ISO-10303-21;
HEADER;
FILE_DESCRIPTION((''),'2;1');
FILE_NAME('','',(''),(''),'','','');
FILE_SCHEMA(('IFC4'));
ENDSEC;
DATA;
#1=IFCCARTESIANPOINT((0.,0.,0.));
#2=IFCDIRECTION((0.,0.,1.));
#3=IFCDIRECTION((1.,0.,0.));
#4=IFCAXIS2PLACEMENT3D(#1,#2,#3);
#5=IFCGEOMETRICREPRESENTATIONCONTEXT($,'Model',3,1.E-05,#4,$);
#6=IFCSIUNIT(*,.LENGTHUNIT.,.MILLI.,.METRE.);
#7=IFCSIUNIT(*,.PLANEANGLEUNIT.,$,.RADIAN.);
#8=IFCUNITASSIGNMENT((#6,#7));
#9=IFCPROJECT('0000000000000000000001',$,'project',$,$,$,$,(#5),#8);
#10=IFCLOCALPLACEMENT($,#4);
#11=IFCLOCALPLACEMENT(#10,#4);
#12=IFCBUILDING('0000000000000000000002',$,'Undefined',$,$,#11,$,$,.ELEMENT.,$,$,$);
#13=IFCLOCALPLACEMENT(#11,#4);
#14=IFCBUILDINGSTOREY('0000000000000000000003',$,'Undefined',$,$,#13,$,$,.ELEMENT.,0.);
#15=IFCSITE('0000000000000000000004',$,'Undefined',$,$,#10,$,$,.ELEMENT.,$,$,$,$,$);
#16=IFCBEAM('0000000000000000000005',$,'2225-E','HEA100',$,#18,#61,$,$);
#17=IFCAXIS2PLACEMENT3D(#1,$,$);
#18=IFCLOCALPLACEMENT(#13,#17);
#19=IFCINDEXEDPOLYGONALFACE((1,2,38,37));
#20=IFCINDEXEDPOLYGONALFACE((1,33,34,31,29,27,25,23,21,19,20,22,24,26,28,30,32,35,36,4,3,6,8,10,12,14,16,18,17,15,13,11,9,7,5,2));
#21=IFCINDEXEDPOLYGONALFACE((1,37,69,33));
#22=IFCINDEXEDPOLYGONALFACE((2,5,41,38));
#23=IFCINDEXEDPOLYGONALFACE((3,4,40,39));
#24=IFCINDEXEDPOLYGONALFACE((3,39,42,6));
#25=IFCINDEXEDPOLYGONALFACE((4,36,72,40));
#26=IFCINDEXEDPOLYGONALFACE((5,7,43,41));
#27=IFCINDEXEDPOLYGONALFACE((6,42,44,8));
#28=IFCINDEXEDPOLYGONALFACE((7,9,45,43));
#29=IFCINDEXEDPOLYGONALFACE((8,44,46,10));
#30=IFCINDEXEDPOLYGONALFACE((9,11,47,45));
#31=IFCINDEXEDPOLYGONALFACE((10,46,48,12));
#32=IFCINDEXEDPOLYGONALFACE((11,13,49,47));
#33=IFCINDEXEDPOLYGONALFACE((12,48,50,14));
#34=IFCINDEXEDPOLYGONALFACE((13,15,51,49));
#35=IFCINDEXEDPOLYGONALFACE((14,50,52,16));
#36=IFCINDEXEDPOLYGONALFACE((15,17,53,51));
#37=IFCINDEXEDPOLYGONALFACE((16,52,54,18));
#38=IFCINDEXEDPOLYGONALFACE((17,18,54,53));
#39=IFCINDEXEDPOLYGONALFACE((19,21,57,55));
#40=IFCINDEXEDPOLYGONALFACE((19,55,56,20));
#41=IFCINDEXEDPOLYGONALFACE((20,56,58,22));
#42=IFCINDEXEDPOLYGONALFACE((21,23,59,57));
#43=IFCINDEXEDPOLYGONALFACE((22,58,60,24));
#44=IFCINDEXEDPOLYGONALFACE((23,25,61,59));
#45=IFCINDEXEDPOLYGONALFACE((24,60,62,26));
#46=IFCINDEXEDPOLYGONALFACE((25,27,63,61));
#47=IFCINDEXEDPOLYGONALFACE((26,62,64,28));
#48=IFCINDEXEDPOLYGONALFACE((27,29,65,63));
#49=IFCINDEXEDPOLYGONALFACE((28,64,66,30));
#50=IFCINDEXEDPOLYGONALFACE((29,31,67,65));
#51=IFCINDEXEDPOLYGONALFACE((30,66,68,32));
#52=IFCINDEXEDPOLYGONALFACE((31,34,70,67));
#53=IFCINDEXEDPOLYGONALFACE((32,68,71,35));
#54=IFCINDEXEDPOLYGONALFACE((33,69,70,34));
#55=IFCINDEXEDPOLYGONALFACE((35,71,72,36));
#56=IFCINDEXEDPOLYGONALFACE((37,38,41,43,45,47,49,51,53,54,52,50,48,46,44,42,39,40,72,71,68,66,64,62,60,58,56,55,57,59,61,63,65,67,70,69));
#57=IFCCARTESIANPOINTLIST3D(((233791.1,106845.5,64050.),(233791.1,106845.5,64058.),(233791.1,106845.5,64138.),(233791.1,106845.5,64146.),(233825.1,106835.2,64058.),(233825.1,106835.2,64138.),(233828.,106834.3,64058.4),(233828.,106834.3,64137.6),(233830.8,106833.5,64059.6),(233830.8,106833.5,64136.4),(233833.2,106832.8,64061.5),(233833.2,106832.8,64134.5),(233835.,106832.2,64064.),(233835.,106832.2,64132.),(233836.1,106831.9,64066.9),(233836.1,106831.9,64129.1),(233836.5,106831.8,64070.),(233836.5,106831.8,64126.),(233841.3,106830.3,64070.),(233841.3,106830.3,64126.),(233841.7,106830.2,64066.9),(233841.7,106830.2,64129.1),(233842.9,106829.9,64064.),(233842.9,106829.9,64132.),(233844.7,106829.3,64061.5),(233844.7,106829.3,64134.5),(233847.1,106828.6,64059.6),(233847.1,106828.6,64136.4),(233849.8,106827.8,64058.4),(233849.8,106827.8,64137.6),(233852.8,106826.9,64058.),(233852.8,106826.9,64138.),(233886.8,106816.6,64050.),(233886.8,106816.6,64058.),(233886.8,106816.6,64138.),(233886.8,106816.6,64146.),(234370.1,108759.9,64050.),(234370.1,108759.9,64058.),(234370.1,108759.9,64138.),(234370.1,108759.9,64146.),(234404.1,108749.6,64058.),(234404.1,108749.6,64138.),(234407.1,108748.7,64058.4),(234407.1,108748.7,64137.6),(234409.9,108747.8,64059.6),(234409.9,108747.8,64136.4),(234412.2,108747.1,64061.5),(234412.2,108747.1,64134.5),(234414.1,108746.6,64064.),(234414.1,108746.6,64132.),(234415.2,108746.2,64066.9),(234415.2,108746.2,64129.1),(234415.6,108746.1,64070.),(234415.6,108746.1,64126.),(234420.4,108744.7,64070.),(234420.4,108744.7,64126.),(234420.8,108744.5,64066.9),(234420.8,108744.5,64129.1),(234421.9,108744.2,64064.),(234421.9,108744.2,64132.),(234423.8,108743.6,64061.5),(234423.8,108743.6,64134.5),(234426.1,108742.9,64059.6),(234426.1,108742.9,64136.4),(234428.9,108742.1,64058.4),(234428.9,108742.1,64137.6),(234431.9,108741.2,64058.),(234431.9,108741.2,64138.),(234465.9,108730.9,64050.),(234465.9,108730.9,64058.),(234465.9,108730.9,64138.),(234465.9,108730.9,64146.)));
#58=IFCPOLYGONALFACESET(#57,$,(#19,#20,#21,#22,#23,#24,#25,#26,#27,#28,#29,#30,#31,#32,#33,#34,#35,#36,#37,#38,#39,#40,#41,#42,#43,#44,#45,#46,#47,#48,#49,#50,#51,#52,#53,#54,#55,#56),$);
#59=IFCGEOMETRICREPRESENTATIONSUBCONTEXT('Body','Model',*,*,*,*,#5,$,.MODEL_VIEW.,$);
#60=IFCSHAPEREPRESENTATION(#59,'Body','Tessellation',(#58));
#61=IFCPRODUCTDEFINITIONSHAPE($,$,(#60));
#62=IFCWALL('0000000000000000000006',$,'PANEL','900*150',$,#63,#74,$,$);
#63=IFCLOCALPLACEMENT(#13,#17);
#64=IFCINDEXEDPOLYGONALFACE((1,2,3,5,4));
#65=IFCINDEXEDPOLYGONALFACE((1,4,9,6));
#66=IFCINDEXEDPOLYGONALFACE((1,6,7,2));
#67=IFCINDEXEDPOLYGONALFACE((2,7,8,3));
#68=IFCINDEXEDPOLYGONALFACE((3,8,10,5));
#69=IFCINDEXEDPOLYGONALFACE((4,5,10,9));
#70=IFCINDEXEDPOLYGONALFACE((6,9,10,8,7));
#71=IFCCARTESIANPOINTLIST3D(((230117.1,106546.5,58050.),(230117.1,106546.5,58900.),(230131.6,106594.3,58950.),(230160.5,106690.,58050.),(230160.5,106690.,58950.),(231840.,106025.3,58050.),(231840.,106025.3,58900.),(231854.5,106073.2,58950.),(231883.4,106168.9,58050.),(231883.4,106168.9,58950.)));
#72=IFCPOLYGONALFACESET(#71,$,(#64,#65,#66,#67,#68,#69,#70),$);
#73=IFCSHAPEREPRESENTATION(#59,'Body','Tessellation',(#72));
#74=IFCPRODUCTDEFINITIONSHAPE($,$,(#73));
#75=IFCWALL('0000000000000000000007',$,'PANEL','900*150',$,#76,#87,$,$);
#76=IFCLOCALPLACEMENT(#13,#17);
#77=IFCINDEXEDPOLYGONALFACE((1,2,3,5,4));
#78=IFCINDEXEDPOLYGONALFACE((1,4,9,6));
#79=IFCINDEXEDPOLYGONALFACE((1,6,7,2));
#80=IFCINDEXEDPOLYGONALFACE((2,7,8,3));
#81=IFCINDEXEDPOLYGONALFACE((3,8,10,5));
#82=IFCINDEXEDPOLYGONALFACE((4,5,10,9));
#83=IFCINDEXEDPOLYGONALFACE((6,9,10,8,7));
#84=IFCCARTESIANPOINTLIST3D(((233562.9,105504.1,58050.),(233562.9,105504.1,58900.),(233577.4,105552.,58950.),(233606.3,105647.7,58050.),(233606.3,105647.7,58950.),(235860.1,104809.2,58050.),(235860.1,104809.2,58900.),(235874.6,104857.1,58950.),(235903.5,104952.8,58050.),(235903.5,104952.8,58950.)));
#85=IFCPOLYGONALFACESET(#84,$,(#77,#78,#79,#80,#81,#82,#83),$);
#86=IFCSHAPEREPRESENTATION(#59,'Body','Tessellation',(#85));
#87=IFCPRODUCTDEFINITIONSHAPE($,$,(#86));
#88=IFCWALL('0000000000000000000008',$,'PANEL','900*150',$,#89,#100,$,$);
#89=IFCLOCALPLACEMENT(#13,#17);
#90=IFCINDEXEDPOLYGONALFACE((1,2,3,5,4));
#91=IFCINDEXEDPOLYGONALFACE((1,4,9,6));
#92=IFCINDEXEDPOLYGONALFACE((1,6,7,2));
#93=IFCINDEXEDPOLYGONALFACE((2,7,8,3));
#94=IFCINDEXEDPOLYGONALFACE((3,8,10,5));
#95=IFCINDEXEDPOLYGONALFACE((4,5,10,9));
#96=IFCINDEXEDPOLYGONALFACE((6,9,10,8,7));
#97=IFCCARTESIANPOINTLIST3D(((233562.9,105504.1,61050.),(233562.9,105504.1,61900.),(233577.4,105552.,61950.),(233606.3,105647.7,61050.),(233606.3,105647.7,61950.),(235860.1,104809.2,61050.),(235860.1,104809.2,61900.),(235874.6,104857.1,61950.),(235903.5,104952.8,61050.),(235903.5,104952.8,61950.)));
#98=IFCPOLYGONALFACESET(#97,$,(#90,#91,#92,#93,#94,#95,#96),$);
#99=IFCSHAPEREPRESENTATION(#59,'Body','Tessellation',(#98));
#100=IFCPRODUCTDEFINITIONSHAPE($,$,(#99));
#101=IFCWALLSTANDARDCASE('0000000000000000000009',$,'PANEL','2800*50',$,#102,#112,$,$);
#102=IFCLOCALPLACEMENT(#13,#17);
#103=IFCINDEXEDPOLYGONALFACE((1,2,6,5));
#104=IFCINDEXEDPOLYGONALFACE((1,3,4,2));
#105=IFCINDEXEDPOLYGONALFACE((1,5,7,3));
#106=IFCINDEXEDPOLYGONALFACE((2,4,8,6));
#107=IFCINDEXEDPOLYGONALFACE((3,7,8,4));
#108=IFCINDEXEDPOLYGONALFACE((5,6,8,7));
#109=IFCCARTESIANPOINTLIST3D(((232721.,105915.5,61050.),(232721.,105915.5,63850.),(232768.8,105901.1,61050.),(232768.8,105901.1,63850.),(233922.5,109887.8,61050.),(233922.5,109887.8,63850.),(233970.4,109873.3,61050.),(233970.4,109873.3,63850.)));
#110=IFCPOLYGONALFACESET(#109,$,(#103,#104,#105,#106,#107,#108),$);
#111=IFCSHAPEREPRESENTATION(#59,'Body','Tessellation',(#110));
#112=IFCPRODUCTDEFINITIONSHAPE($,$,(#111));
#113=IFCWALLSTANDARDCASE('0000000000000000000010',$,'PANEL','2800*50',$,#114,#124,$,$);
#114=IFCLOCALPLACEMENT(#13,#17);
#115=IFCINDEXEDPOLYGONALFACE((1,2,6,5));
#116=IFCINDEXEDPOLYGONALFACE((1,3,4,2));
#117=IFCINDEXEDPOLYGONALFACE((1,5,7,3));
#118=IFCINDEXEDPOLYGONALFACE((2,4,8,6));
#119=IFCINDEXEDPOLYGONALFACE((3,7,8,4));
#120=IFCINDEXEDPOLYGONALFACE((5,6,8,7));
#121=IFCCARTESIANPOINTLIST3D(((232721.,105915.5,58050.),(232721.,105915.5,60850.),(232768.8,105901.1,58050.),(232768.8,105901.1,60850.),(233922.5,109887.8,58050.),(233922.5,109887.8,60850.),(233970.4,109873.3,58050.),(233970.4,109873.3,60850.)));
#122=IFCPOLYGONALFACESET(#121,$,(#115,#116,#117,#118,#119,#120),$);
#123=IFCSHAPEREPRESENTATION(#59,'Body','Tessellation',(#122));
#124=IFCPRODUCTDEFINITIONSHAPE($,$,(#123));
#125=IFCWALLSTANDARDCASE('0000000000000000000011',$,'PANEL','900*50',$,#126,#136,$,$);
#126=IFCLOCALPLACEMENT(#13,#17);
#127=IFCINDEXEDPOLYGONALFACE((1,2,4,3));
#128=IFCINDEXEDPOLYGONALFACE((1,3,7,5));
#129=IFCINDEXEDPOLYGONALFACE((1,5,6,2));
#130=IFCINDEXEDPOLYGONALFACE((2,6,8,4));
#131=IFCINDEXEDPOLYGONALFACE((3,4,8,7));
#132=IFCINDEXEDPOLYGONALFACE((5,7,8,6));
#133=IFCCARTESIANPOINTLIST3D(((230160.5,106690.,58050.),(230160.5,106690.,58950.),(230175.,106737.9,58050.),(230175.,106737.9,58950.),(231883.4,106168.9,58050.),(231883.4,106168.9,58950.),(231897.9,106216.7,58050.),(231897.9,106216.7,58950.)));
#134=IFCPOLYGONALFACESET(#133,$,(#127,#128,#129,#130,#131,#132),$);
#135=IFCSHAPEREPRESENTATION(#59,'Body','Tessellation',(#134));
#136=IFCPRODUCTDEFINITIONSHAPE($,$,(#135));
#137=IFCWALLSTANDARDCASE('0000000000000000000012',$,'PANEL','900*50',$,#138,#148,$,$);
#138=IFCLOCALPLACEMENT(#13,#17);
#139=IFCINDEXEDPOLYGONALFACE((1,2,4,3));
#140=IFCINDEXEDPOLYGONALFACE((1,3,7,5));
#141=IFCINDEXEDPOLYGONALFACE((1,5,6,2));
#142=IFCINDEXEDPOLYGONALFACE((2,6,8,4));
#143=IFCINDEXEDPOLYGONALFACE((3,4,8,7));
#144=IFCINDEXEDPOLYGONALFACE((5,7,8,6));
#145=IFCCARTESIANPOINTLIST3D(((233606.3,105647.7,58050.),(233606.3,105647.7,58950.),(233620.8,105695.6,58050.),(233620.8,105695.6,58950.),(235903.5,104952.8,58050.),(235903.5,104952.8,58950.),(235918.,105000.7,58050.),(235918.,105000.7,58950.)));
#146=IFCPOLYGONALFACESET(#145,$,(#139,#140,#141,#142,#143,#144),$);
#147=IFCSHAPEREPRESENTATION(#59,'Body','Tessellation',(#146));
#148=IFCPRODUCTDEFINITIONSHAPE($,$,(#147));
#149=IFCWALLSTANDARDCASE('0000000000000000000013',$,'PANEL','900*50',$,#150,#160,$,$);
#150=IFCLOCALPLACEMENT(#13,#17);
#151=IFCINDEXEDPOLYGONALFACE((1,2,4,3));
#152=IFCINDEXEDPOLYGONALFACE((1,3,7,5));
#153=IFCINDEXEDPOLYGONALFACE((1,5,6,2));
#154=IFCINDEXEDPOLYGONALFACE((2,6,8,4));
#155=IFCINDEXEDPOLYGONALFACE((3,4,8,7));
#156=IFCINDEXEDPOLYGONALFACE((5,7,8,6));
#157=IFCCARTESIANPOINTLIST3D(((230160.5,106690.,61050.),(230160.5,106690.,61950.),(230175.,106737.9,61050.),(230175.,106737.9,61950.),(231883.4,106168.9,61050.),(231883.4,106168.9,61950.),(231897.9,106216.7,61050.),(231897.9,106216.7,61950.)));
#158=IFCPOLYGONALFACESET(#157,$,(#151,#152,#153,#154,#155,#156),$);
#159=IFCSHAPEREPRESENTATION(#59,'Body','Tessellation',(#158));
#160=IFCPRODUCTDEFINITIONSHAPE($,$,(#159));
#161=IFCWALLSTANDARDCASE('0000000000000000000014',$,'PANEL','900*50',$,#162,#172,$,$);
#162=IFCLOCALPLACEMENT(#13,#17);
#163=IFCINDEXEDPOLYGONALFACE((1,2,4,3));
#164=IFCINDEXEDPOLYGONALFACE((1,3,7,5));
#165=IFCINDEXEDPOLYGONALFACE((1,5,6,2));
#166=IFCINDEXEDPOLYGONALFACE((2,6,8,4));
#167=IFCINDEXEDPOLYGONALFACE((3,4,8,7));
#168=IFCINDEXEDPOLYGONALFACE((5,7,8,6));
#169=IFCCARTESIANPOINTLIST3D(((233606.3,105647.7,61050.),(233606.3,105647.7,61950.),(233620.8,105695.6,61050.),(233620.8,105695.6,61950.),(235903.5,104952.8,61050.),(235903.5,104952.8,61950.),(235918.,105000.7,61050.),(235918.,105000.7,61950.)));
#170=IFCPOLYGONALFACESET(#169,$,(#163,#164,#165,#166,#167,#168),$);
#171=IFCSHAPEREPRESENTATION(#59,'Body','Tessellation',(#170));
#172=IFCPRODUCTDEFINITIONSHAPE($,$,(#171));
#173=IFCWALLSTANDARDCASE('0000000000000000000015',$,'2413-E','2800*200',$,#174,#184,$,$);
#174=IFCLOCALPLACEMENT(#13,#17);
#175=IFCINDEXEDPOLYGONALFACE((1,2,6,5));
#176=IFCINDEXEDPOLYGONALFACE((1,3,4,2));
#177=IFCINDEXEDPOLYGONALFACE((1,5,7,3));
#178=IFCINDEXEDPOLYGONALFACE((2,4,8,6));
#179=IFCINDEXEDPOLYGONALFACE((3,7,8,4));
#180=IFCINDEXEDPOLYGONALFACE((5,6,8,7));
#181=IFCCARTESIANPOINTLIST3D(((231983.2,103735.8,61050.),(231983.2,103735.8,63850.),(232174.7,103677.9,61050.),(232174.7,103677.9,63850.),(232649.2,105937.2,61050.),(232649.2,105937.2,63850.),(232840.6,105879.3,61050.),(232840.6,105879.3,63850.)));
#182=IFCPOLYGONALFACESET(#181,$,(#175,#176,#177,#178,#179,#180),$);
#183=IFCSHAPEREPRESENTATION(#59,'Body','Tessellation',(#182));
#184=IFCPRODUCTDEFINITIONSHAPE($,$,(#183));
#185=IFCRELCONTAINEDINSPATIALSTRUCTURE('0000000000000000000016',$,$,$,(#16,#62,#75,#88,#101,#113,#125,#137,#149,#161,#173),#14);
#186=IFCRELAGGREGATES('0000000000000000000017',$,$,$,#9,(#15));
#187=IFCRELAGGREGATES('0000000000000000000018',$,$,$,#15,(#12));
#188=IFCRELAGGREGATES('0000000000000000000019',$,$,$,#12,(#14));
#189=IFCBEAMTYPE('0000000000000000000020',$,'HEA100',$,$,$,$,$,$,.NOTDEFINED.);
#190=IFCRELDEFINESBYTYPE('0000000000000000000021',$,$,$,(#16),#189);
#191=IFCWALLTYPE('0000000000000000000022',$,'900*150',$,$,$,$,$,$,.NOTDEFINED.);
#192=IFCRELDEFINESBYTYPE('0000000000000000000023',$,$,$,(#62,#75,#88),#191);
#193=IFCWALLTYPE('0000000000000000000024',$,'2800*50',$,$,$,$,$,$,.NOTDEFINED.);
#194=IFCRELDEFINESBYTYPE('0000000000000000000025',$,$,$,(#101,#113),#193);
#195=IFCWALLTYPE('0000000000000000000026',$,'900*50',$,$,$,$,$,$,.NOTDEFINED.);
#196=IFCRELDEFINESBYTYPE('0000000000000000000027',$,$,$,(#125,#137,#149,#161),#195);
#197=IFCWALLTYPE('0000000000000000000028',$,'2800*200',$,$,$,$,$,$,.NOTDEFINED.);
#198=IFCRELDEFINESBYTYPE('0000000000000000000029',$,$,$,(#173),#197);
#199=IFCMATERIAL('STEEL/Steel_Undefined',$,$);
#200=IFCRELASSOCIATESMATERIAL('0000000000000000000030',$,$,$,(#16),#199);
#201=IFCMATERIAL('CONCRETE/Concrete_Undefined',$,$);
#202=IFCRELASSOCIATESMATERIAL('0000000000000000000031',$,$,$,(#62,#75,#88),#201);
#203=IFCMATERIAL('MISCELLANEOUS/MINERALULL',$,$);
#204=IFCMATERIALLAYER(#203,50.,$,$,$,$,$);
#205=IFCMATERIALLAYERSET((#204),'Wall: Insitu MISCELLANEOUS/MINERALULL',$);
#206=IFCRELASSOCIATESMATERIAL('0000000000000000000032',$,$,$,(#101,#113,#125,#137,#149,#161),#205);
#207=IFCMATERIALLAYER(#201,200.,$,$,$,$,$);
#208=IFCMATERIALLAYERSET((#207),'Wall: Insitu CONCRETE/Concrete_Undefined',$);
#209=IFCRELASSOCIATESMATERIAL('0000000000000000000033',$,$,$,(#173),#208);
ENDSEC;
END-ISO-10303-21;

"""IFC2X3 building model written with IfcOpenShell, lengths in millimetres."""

from ifc_helpers import new_model, si_unit, frame, frame_2d, origin_with_axes, origin_2d_with_axis, place, context, subcontext, project, spatial, rectangle, i_section, extrude, clip, halfspace, material, layer, layer_set, layer_usage, type_object, element, save


model = new_model("IFC2X3")

# Units and contexts
model_context = context("Model", 3, precision=1e-05, world=origin_with_axes())
body_context = subcontext(model_context, "Body", "Model", "MODEL_VIEW")
ifc_project = project(units=[si_unit("LENGTHUNIT", "METRE", prefix="MILLI"), si_unit("PLANEANGLEUNIT", "RADIAN")], contexts=[model_context])

# Site, building, storey
site_placement = place(None, origin_with_axes())
site = spatial("IfcSite", under=ifc_project, at=site_placement, Name="Undefined", CompositionType="ELEMENT")
building_placement = place(site_placement, origin_with_axes())
building = spatial("IfcBuilding", under=site, at=building_placement, Name="Undefined", CompositionType="ELEMENT")
storey_placement = place(building_placement, origin_with_axes())
storey = spatial("IfcBuildingStorey", under=building, at=storey_placement, Name="Undefined", CompositionType="ELEMENT", Elevation=0.0)

# Beam
ifc_material_1 = material(Name="STEEL/Steel_Undefined")
beam_type_1 = type_object("IfcBeamType", Name="HEA100", PredefinedType="NOTDEFINED")
beam_1_placement = place(storey_placement, frame((233838.9, 106831.1, 64098.0), z_axis=(0.0, 0.0, 1.0), x_axis=(0.289538, 0.957166, 0.0)))
element("IfcBeam", 1, at=beam_1_placement, inside=storey, type_object=beam_type_1, material=ifc_material_1, Name="2225-E", Description="HEA100", context=body_context, shape_type="SweptSolid", body=[
    extrude(i_section(OverallWidth=100.0, OverallDepth=96.0, WebThickness=5.0, FlangeThickness=8.0, FilletRadius=12.0, at=origin_2d_with_axis()), frame((2000.0, 0.0, 0.0), z_axis=(-1.0, 0.0, 0.0), x_axis=(0.0, -1.0, 0.0)), (0.0, 0.0, 1.0), 2000.0),
])

# Walls
ifc_material_2 = material(Name="CONCRETE/Concrete_Undefined")
wall_type_1 = type_object("IfcWallType", Name="900*150", PredefinedType="NOTDEFINED")
wall_1_placement = place(storey_placement, frame((230138.8, 106618.3, 58050.0), z_axis=(0.0, 0.0, 1.0), x_axis=(0.957166, -0.289541, 0.0)))
element("IfcWall", 2, at=wall_1_placement, inside=storey, type_object=wall_type_1, material=ifc_material_2, Name="PANEL", Description="900*150", context=body_context, shape_type="Clipping", body=[
    clip(extrude(rectangle(XDim=1800.0, YDim=150.0, at=frame_2d((0.0, 900.0), x_axis=(0.0, -1.0))), frame((0.0, 0.0, 0.0), z_axis=(0.0, 0.0, 1.0), x_axis=(0.0, -1.0, 0.0)), (0.0, 0.0, 1.0), 900.0), halfspace(frame((2400.0, 75.0, 1000.0), z_axis=(0.000001, -0.707072, 0.707141), x_axis=(0.0, -0.707141, -0.707072)), False)),
])
for number, where, z_axis, x_axis, name in (
    (3, (233584.6, 105575.9, 58050.0), (0.0, 0.0, 1.0), (0.957166, -0.289539, 0.0), "PANEL"),
    (4, (233584.6, 105575.9, 61050.0), (0.0, 0.0, 1.0), (0.957166, -0.289539, 0.0), "PANEL"),
):
    element("IfcWall", number, at=place(storey_placement, frame(where, z_axis=z_axis, x_axis=x_axis)), inside=storey, type_object=wall_type_1, material=ifc_material_2, Name=name, Description="900*150", context=body_context, shape_type="Clipping", body=[
        clip(extrude(rectangle(XDim=2400.0, YDim=150.0, at=frame_2d((0.0, 1200.0), x_axis=(0.0, -1.0))), frame((0.0, 0.0, 0.0), z_axis=(0.0, 0.0, 1.0), x_axis=(0.0, -1.0, 0.0)), (0.0, 0.0, 1.0), 900.0), halfspace(frame((2400.0, 75.0, 1000.0), z_axis=(0.000001, -0.707072, 0.707141), x_axis=(0.0, -0.707141, -0.707072)), False)),
    ])
ifc_material_3 = material(Name="MISCELLANEOUS/MINERALULL")
ifc_layer_1 = layer(ifc_material_3, 50.0)
ifc_layer_set_1 = layer_set([ifc_layer_1], Name="Wall: Insitu MISCELLANEOUS/MINERALULL")
ifc_layer_usage_1 = layer_usage(ifc_layer_set_1, "AXIS2", "POSITIVE", -25.0)
wall_type_2 = type_object("IfcWallType", Name="2800*50", PredefinedType="NOTDEFINED")
wall_2_placement = place(storey_placement, frame((232744.9, 105908.3, 61050.0), z_axis=(0.0, 0.0, 1.0), x_axis=(0.289539, 0.957166, 0.0)))
element("IfcWallStandardCase", 5, at=wall_2_placement, inside=storey, type_object=wall_type_2, material=ifc_layer_usage_1, Name="PANEL", Description="2800*50", context=body_context, shape_type="SweptSolid", body=[
    extrude(rectangle(XDim=4150.0, YDim=50.0, at=frame_2d((0.0, 2075.0), x_axis=(0.0, -1.0))), frame((0.0, 0.0, 0.0), z_axis=(0.0, 0.0, 1.0), x_axis=(0.0, -1.0, 0.0)), (0.0, 0.0, 1.0), 2800.0),
])
ifc_layer_usage_2 = layer_usage(ifc_layer_set_1, "AXIS2", "POSITIVE", -25.0)
wall_3_placement = place(storey_placement, frame((232744.9, 105908.3, 58050.0), z_axis=(0.0, 0.0, 1.0), x_axis=(0.289539, 0.957166, 0.0)))
element("IfcWallStandardCase", 6, at=wall_3_placement, inside=storey, type_object=wall_type_2, material=ifc_layer_usage_2, Name="PANEL", Description="2800*50", context=body_context, shape_type="SweptSolid", body=[
    extrude(rectangle(XDim=4150.0, YDim=50.0, at=frame_2d((0.0, 2075.0), x_axis=(0.0, -1.0))), frame((0.0, 0.0, 0.0), z_axis=(0.0, 0.0, 1.0), x_axis=(0.0, -1.0, 0.0)), (0.0, 0.0, 1.0), 2800.0),
])
ifc_layer_usage_3 = layer_usage(ifc_layer_set_1, "AXIS2", "POSITIVE", -25.0)
wall_type_3 = type_object("IfcWallType", Name="900*50", PredefinedType="NOTDEFINED")
wall_4_placement = place(storey_placement, frame((230167.8, 106714.0, 58050.0), z_axis=(0.0, 0.0, 1.0), x_axis=(0.957166, -0.289541, 0.0)))
element("IfcWallStandardCase", 7, at=wall_4_placement, inside=storey, type_object=wall_type_3, material=ifc_layer_usage_3, Name="PANEL", Description="900*50", context=body_context, shape_type="SweptSolid", body=[
    extrude(rectangle(XDim=1800.0, YDim=50.0, at=frame_2d((0.0, 900.0), x_axis=(0.0, -1.0))), frame((0.0, 0.0, 0.0), z_axis=(0.0, 0.0, 1.0), x_axis=(0.0, -1.0, 0.0)), (0.0, 0.0, 1.0), 900.0),
])
ifc_layer_usage_4 = layer_usage(ifc_layer_set_1, "AXIS2", "POSITIVE", -25.0)
wall_5_placement = place(storey_placement, frame((233613.6, 105671.6, 58050.0), z_axis=(0.0, 0.0, 1.0), x_axis=(0.957166, -0.289539, 0.0)))
element("IfcWallStandardCase", 8, at=wall_5_placement, inside=storey, type_object=wall_type_3, material=ifc_layer_usage_4, Name="PANEL", Description="900*50", context=body_context, shape_type="SweptSolid", body=[
    extrude(rectangle(XDim=2400.0, YDim=50.0, at=frame_2d((0.0, 1200.0), x_axis=(0.0, -1.0))), frame((0.0, 0.0, 0.0), z_axis=(0.0, 0.0, 1.0), x_axis=(0.0, -1.0, 0.0)), (0.0, 0.0, 1.0), 900.0),
])
ifc_layer_usage_5 = layer_usage(ifc_layer_set_1, "AXIS2", "POSITIVE", -25.0)
wall_6_placement = place(storey_placement, frame((230167.8, 106714.0, 61050.0), z_axis=(0.0, 0.0, 1.0), x_axis=(0.957166, -0.289541, 0.0)))
element("IfcWallStandardCase", 9, at=wall_6_placement, inside=storey, type_object=wall_type_3, material=ifc_layer_usage_5, Name="PANEL", Description="900*50", context=body_context, shape_type="SweptSolid", body=[
    extrude(rectangle(XDim=1800.0, YDim=50.0, at=frame_2d((0.0, 900.0), x_axis=(0.0, -1.0))), frame((0.0, 0.0, 0.0), z_axis=(0.0, 0.0, 1.0), x_axis=(0.0, -1.0, 0.0)), (0.0, 0.0, 1.0), 900.0),
])
ifc_layer_usage_6 = layer_usage(ifc_layer_set_1, "AXIS2", "POSITIVE", -25.0)
wall_7_placement = place(storey_placement, frame((233613.6, 105671.6, 61050.0), z_axis=(0.0, 0.0, 1.0), x_axis=(0.957166, -0.289539, 0.0)))
element("IfcWallStandardCase", 10, at=wall_7_placement, inside=storey, type_object=wall_type_3, material=ifc_layer_usage_6, Name="PANEL", Description="900*50", context=body_context, shape_type="SweptSolid", body=[
    extrude(rectangle(XDim=2400.0, YDim=50.0, at=frame_2d((0.0, 1200.0), x_axis=(0.0, -1.0))), frame((0.0, 0.0, 0.0), z_axis=(0.0, 0.0, 1.0), x_axis=(0.0, -1.0, 0.0)), (0.0, 0.0, 1.0), 900.0),
])
ifc_layer_2 = layer(ifc_material_2, 200.0)
ifc_layer_set_2 = layer_set([ifc_layer_2], Name="Wall: Insitu CONCRETE/Concrete_Undefined")
ifc_layer_usage_7 = layer_usage(ifc_layer_set_2, "AXIS2", "POSITIVE", -100.0)
wall_type_4 = type_object("IfcWallType", Name="2800*200", PredefinedType="NOTDEFINED")
wall_8_placement = place(storey_placement, frame((232079.0, 103706.8, 61050.0), z_axis=(0.0, 0.0, 1.0), x_axis=(0.289536, 0.957167, 0.0)))
element("IfcWallStandardCase", 11, at=wall_8_placement, inside=storey, type_object=wall_type_4, material=ifc_layer_usage_7, Name="2413-E", Description="2800*200", context=body_context, shape_type="SweptSolid", body=[
    extrude(rectangle(XDim=2300.0, YDim=200.0, at=frame_2d((0.0, 1150.0), x_axis=(0.0, -1.0))), frame((0.0, 0.0, 0.0), z_axis=(0.0, 0.0, 1.0), x_axis=(0.0, -1.0, 0.0)), (0.0, 0.0, 1.0), 2800.0),
])

save(model, "model.ifc")
